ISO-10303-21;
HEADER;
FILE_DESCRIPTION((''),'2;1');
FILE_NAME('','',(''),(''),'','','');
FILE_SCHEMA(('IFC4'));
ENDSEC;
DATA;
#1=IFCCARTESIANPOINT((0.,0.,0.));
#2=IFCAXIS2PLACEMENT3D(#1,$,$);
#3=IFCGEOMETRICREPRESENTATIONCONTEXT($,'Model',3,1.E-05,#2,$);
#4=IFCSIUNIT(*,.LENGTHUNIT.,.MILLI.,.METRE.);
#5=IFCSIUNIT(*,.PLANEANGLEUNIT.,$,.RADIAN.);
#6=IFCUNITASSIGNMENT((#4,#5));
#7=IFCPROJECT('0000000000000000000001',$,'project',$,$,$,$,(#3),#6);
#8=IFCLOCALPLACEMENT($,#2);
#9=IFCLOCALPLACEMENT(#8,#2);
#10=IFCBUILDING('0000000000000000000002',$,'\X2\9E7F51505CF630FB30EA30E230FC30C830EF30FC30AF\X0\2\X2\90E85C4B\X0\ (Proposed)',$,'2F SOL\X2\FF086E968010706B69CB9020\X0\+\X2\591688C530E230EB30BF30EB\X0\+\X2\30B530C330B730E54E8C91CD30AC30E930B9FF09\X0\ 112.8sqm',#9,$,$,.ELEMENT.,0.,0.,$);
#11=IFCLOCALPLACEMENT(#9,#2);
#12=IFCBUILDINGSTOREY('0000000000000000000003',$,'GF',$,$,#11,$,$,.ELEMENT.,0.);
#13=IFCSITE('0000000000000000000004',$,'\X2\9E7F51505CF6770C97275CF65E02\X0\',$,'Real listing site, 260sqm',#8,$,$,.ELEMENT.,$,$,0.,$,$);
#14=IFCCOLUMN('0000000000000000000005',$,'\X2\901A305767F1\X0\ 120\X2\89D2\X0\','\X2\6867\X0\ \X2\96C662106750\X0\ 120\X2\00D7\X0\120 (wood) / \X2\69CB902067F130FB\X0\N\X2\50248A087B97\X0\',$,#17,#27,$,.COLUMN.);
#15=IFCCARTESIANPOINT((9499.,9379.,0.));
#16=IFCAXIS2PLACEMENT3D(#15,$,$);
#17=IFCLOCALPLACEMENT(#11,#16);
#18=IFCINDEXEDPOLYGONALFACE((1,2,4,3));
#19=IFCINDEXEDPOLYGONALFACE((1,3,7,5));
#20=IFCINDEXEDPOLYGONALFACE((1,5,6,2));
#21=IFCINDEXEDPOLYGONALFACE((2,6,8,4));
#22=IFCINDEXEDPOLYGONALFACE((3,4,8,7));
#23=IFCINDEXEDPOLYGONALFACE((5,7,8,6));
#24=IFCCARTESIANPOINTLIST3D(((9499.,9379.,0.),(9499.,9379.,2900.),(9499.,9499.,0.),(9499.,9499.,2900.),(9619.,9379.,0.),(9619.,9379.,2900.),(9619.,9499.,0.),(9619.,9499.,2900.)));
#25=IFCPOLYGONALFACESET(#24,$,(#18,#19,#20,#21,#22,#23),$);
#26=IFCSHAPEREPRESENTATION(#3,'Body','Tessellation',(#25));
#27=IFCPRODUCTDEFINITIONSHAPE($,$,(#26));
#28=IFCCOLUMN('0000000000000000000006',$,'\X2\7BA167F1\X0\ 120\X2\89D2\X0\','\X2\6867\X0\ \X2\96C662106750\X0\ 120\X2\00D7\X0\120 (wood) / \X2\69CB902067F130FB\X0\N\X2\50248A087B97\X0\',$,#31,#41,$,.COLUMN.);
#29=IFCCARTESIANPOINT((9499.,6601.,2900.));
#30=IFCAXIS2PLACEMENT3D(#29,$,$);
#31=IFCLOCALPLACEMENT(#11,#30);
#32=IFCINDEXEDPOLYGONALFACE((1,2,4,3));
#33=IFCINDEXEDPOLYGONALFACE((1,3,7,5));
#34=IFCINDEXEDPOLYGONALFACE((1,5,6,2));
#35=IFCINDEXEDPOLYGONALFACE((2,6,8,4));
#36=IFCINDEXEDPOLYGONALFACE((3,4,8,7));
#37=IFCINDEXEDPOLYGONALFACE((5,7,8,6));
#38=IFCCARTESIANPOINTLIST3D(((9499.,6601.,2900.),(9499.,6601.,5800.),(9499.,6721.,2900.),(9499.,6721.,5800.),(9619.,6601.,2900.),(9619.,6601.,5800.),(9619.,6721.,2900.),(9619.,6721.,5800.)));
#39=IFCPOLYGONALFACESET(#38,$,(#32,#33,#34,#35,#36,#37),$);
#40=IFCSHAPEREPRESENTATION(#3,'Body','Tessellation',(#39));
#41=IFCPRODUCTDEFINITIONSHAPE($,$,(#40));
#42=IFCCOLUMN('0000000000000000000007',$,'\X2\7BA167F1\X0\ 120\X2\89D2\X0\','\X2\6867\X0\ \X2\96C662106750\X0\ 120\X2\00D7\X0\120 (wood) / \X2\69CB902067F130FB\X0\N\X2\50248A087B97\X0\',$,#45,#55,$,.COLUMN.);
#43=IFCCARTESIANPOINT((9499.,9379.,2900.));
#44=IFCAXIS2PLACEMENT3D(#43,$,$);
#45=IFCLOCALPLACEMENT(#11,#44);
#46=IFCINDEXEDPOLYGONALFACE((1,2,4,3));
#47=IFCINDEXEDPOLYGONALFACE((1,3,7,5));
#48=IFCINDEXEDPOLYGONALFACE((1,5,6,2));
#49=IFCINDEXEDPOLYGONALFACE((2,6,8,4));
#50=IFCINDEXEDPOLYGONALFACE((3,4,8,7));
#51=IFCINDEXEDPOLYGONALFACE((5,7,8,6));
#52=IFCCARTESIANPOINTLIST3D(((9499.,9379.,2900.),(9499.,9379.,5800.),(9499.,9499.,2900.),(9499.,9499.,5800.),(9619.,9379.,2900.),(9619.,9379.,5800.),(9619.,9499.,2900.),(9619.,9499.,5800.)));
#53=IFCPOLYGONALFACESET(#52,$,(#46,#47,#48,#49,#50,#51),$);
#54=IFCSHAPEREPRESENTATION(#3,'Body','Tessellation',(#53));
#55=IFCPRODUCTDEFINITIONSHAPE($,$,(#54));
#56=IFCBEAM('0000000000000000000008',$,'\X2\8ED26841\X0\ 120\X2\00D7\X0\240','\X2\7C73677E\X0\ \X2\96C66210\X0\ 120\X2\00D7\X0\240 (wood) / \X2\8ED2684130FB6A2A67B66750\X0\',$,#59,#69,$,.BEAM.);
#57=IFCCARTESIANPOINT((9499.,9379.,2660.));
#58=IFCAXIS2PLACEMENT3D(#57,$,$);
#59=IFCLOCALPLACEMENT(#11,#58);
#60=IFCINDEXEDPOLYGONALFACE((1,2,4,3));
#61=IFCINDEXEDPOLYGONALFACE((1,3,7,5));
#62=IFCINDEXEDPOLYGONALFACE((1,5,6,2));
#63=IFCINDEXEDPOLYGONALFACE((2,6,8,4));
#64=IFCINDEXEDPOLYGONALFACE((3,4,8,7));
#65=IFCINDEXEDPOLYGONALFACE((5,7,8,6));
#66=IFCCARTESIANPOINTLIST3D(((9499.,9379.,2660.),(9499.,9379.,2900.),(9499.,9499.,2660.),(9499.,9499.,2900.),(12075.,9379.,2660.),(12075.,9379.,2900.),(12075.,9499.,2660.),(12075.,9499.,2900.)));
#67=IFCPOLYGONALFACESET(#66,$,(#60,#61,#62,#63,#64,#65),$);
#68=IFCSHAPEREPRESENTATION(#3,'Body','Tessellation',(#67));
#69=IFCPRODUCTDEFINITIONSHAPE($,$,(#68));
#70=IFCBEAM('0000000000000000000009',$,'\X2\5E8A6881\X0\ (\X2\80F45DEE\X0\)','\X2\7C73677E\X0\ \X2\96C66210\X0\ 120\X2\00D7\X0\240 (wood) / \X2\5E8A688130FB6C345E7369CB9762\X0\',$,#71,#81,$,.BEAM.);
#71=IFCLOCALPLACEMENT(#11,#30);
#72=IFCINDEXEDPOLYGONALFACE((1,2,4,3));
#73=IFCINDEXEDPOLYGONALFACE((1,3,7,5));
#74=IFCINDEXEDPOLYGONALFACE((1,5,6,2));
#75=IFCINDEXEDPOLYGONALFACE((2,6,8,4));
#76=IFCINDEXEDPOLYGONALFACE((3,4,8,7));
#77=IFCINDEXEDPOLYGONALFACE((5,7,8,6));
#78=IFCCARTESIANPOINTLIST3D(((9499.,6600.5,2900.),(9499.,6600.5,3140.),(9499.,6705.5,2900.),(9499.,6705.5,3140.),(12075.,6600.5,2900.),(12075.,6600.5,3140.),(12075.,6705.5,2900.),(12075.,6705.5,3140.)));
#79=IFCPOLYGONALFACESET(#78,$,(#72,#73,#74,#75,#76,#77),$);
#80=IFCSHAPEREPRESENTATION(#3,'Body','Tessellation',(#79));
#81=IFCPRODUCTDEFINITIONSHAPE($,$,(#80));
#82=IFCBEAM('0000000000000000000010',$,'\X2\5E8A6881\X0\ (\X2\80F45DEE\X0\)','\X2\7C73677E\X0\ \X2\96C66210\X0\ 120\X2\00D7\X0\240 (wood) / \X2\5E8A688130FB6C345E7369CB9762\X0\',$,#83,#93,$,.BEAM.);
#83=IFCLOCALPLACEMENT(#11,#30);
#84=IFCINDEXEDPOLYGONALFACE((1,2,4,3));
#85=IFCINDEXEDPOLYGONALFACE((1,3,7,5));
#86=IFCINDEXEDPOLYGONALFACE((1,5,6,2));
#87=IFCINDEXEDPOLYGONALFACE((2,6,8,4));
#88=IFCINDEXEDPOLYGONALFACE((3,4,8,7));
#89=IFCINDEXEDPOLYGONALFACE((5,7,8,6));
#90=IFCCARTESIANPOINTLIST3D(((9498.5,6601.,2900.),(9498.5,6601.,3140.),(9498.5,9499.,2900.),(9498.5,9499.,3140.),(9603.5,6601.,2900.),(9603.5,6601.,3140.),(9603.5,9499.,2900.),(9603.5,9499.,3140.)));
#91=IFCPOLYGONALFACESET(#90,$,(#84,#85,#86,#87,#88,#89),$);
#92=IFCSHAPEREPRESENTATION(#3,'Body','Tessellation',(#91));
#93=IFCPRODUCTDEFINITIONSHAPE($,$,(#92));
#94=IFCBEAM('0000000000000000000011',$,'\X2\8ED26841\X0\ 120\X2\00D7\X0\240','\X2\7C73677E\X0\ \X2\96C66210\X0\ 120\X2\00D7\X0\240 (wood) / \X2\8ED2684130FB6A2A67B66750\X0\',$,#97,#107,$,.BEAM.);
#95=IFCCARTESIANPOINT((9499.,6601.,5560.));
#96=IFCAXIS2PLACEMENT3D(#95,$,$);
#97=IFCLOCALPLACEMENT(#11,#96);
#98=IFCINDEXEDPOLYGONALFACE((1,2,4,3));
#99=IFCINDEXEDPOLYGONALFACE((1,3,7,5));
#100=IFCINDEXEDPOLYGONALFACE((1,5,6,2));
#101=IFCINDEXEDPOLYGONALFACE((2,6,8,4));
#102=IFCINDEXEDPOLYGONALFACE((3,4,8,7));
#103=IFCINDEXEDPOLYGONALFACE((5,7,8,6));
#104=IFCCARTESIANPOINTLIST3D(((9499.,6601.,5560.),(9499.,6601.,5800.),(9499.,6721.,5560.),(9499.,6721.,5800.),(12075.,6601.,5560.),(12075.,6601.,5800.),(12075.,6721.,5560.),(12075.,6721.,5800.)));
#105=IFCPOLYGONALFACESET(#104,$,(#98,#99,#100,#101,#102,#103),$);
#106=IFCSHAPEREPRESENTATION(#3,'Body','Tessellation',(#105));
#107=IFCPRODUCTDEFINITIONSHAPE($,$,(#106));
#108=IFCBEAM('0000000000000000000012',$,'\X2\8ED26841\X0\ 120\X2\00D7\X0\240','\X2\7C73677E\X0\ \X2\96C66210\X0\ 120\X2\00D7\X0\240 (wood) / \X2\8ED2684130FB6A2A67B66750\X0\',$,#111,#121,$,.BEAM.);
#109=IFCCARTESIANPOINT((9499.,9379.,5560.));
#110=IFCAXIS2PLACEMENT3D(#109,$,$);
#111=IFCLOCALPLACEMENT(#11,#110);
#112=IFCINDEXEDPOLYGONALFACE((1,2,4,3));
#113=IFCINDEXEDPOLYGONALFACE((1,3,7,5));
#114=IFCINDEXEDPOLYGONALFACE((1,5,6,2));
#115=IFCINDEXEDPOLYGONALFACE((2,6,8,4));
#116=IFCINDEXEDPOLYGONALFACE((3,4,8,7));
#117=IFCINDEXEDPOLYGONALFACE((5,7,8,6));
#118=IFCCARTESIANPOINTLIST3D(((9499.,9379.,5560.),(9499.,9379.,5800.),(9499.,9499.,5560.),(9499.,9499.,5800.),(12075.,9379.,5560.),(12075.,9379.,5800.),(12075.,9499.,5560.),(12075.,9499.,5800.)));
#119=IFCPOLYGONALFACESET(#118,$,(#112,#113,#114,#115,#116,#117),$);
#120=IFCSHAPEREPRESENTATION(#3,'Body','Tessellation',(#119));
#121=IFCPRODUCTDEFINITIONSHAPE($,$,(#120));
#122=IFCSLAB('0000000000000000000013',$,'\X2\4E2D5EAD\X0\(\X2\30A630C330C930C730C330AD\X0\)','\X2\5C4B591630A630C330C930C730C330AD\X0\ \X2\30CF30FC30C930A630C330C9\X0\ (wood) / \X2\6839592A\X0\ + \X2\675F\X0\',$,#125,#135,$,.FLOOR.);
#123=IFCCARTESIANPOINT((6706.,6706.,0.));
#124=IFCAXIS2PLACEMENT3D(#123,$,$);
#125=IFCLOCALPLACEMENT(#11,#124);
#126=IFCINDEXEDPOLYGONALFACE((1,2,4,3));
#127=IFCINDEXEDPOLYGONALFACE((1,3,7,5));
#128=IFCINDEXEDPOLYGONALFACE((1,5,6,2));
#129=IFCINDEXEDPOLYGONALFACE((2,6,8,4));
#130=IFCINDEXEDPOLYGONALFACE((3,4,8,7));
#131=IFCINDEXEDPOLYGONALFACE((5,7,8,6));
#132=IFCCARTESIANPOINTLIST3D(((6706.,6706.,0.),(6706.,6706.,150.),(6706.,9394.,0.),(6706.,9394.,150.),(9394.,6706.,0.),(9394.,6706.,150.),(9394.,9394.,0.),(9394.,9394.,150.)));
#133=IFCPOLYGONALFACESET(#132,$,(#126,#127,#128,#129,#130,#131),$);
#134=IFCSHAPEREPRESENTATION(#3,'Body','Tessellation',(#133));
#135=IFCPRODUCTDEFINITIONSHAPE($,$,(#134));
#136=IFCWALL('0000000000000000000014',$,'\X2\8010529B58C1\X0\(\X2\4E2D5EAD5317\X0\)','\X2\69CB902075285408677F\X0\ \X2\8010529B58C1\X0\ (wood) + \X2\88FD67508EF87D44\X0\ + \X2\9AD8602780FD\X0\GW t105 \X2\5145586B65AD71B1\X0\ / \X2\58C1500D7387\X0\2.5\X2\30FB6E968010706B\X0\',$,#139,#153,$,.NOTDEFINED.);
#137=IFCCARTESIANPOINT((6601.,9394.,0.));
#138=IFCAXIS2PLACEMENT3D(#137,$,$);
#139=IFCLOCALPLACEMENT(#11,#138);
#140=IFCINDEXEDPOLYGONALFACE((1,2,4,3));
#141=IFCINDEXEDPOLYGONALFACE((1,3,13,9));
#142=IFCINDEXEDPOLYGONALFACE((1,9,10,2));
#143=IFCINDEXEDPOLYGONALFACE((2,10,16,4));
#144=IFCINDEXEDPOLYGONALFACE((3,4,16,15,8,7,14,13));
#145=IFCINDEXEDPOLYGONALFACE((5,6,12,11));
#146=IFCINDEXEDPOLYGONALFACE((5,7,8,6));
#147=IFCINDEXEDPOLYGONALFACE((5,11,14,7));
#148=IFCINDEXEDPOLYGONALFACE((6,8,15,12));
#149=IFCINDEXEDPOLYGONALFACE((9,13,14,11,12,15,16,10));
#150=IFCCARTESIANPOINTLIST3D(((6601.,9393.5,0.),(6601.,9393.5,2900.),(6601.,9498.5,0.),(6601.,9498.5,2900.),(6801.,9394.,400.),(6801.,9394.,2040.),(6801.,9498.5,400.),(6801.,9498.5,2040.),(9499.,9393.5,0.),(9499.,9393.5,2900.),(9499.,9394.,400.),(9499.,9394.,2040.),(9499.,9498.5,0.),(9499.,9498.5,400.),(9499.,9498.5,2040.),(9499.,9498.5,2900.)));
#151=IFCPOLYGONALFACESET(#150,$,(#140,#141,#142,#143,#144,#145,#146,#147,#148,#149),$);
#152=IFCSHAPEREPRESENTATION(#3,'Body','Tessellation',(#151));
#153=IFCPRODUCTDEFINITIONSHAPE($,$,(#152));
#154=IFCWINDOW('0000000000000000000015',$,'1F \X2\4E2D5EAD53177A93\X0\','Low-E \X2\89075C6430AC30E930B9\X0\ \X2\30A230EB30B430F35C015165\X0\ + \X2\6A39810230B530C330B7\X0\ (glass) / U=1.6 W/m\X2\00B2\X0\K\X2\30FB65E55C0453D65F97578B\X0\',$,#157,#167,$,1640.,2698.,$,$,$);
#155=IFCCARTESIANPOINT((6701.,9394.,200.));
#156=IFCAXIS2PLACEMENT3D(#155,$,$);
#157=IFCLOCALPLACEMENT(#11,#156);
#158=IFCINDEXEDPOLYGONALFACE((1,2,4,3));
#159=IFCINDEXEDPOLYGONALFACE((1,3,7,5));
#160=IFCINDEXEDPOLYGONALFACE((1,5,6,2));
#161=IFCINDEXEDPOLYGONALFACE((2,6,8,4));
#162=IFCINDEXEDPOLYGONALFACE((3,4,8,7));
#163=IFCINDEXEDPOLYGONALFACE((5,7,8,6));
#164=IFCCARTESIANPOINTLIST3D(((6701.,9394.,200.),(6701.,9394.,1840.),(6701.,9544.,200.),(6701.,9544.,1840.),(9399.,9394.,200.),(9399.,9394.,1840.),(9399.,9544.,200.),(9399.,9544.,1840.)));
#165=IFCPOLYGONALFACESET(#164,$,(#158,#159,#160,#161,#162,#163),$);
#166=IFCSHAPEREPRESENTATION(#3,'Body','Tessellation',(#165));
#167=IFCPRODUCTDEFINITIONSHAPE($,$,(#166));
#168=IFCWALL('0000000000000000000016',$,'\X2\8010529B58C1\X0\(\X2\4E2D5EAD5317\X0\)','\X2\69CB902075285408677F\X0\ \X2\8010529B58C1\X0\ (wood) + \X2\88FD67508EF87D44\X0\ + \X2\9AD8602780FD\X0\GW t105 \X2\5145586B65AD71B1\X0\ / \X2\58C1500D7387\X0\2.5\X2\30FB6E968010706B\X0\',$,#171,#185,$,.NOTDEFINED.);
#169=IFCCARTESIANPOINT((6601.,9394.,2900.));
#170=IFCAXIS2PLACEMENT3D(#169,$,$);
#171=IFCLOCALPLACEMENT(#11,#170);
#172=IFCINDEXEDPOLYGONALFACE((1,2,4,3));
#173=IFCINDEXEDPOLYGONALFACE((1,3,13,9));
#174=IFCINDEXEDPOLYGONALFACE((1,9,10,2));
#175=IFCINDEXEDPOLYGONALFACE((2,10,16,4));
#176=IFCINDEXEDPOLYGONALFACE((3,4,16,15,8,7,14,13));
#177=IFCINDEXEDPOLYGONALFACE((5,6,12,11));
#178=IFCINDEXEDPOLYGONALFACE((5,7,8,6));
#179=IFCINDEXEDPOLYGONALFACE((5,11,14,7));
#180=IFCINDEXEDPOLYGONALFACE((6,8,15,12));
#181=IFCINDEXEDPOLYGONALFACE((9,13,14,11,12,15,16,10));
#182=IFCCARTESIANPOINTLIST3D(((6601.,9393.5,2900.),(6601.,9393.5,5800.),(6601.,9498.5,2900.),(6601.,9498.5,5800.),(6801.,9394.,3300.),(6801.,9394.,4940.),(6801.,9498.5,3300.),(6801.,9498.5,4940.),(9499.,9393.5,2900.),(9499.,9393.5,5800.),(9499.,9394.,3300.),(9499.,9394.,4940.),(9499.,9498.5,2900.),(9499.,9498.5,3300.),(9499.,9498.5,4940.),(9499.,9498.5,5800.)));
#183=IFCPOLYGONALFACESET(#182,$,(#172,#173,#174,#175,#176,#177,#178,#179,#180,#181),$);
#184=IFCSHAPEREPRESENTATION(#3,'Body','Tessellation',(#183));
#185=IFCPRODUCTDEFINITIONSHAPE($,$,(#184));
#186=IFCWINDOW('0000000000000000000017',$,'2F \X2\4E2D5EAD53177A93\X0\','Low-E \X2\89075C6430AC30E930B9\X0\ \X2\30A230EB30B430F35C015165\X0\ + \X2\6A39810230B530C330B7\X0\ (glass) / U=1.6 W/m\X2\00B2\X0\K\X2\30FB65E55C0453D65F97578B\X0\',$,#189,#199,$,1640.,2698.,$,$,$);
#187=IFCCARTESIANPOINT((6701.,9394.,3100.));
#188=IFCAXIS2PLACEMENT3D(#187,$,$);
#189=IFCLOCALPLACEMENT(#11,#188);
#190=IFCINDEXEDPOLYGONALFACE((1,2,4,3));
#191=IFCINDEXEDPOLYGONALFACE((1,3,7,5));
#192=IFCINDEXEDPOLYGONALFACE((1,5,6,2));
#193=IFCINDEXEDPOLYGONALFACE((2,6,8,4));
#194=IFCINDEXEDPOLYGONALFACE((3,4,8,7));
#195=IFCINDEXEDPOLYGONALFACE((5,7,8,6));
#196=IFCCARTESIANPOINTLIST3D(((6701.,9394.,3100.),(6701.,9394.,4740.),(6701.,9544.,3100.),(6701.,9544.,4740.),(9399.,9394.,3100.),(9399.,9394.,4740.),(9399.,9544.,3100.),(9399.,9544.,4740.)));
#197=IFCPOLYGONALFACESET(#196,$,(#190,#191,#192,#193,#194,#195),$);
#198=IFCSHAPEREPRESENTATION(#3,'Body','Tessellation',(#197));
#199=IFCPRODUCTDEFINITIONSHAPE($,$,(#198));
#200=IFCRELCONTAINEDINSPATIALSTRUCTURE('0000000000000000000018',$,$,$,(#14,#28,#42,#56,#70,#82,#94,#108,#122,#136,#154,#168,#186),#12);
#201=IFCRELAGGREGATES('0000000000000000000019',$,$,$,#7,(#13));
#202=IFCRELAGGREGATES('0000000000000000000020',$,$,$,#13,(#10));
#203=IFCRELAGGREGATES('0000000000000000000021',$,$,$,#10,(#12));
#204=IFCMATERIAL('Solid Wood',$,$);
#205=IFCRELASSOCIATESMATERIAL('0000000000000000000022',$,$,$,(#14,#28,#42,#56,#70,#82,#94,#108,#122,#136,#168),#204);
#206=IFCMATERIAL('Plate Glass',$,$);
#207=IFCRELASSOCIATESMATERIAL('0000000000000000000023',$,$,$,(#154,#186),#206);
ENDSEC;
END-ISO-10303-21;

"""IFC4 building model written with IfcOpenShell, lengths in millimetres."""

from ifc_helpers import new_model, si_unit, frame, frame_2d, origin, place, context, project, spatial, rectangle, extrude, material, element, fill, save


model = new_model("IFC4")

# Units and contexts
model_context = context("Model", 3, precision=1e-05, world=origin())
ifc_project = project(units=[si_unit("LENGTHUNIT", "METRE", prefix="MILLI"), si_unit("PLANEANGLEUNIT", "RADIAN")], contexts=[model_context])

# Site, building, storey
site_placement = place(None, origin())
site = spatial("IfcSite", under=ifc_project, at=site_placement, Name="鹿児島県霧島市", ObjectType="Real listing site, 260sqm", CompositionType="ELEMENT", RefElevation=0.0)
building_placement = place(site_placement, origin())
building = spatial("IfcBuilding", under=site, at=building_placement, Name="鹿児島・リモートワーク2部屋 (Proposed)", ObjectType="2F SOL（準耐火構造+外装モルタル+サッシュ二重ガラス） 112.8sqm", CompositionType="ELEMENT", ElevationOfRefHeight=0.0, ElevationOfTerrain=0.0)
storey_placement = place(building_placement, origin())
storey = spatial("IfcBuildingStorey", under=building, at=storey_placement, Name="GF", CompositionType="ELEMENT", Elevation=0.0)

# Columns
ifc_material_1 = material(Name="Solid Wood")
column_1_placement = place(storey_placement, frame((9499.0, 9379.0, 0.0)))
element("IfcColumn", 1, at=column_1_placement, inside=storey, material=ifc_material_1, Name="通し柱 120角", Description="桧 集成材 120×120 (wood) / 構造柱・N値計算", PredefinedType="COLUMN", context=model_context, shape_type="SweptSolid", body=[
    extrude(rectangle(XDim=120.0, YDim=120.0, at=frame_2d((60.0, 60.0))), frame((9499.0, 9379.0, 0.0)), (0.0, 0.0, 1.0), 2900.0),
])
column_2_placement = place(storey_placement, frame((9499.0, 6601.0, 2900.0)))
element("IfcColumn", 2, at=column_2_placement, inside=storey, material=ifc_material_1, Name="管柱 120角", Description="桧 集成材 120×120 (wood) / 構造柱・N値計算", PredefinedType="COLUMN", context=model_context, shape_type="SweptSolid", body=[
    extrude(rectangle(XDim=120.0, YDim=120.0, at=frame_2d((60.0, 60.0))), frame((9499.0, 6601.0, 2900.0)), (0.0, 0.0, 1.0), 2900.0),
])
column_3_placement = place(storey_placement, frame((9499.0, 9379.0, 2900.0)))
element("IfcColumn", 3, at=column_3_placement, inside=storey, material=ifc_material_1, Name="管柱 120角", Description="桧 集成材 120×120 (wood) / 構造柱・N値計算", PredefinedType="COLUMN", context=model_context, shape_type="SweptSolid", body=[
    extrude(rectangle(XDim=120.0, YDim=120.0, at=frame_2d((60.0, 60.0))), frame((9499.0, 9379.0, 2900.0)), (0.0, 0.0, 1.0), 2900.0),
])

# Beams
beam_1_placement = place(storey_placement, frame((9499.0, 9379.0, 2660.0)))
element("IfcBeam", 4, at=beam_1_placement, inside=storey, material=ifc_material_1, Name="軒桁 120×240", Description="米松 集成 120×240 (wood) / 軒桁・横架材", PredefinedType="BEAM", context=model_context, shape_type="SweptSolid", body=[
    extrude(rectangle(XDim=2576.0, YDim=120.0, at=frame_2d((1288.0, 60.0))), frame((9499.0, 9379.0, 2660.0)), (0.0, 0.0, 1.0), 240.0),
])
beam_2_placement = place(storey_placement, frame((9499.0, 6601.0, 2900.0)))
element("IfcBeam", 5, at=beam_2_placement, inside=storey, material=ifc_material_1, Name="床梁 (胴差)", Description="米松 集成 120×240 (wood) / 床梁・水平構面", PredefinedType="BEAM", context=model_context, shape_type="SweptSolid", body=[
    extrude(rectangle(XDim=2576.0, YDim=105.0, at=frame_2d((1288.0, 52.0))), frame((9499.0, 6601.0, 2900.0)), (0.0, 0.0, 1.0), 240.0),
])
beam_3_placement = place(storey_placement, frame((9499.0, 6601.0, 2900.0)))
element("IfcBeam", 6, at=beam_3_placement, inside=storey, material=ifc_material_1, Name="床梁 (胴差)", Description="米松 集成 120×240 (wood) / 床梁・水平構面", PredefinedType="BEAM", context=model_context, shape_type="SweptSolid", body=[
    extrude(rectangle(XDim=105.0, YDim=2898.0, at=frame_2d((52.0, 1449.0))), frame((9499.0, 6601.0, 2900.0)), (0.0, 0.0, 1.0), 240.0),
])
beam_4_placement = place(storey_placement, frame((9499.0, 6601.0, 5560.0)))
element("IfcBeam", 7, at=beam_4_placement, inside=storey, material=ifc_material_1, Name="軒桁 120×240", Description="米松 集成 120×240 (wood) / 軒桁・横架材", PredefinedType="BEAM", context=model_context, shape_type="SweptSolid", body=[
    extrude(rectangle(XDim=2576.0, YDim=120.0, at=frame_2d((1288.0, 60.0))), frame((9499.0, 6601.0, 5560.0)), (0.0, 0.0, 1.0), 240.0),
])
beam_5_placement = place(storey_placement, frame((9499.0, 9379.0, 5560.0)))
element("IfcBeam", 8, at=beam_5_placement, inside=storey, material=ifc_material_1, Name="軒桁 120×240", Description="米松 集成 120×240 (wood) / 軒桁・横架材", PredefinedType="BEAM", context=model_context, shape_type="SweptSolid", body=[
    extrude(rectangle(XDim=2576.0, YDim=120.0, at=frame_2d((1288.0, 60.0))), frame((9499.0, 9379.0, 5560.0)), (0.0, 0.0, 1.0), 240.0),
])

# Slab
slab_placement = place(storey_placement, frame((6706.0, 6706.0, 0.0)))
element("IfcSlab", 9, at=slab_placement, inside=storey, material=ifc_material_1, Name="中庭(ウッドデッキ)", Description="屋外ウッドデッキ ハードウッド (wood) / 根太 + 束", PredefinedType="FLOOR", context=model_context, shape_type="SweptSolid", body=[
    extrude(rectangle(XDim=2688.0, YDim=2688.0, at=frame_2d((1344.0, 1344.0))), frame((6706.0, 6706.0, 0.0)), (0.0, 0.0, 1.0), 150.0),
])

# Wall, opening, window
wall_1_placement = place(storey_placement, frame((6601.0, 9394.0, 0.0)))
wall_1 = element("IfcWall", 10, at=wall_1_placement, inside=storey, material=ifc_material_1, Name="耐力壁(中庭北)", Description="構造用合板 耐力壁 (wood) + 製材軸組 + 高性能GW t105 充填断熱 / 壁倍率2.5・準耐火", PredefinedType="NOTDEFINED", context=model_context, shape_type="SweptSolid", body=[
    extrude(rectangle(XDim=2898.0, YDim=105.0, at=frame_2d((1449.0, 52.0))), frame((6601.0, 9394.0, 0.0)), (0.0, 0.0, 1.0), 2900.0),
])
opening_1_placement = place(storey_placement, frame((6701.0, 9394.0, 200.0)))
opening_1 = element("IfcOpeningElement", 11, at=opening_1_placement, cuts=wall_1, PredefinedType="NOTDEFINED", context=model_context, shape_type="SweptSolid", body=[
    extrude(rectangle(XDim=2698.0, YDim=150.0, at=frame_2d((1349.0, 75.0))), frame((6701.0, 9394.0, 200.0)), (0.0, 0.0, 1.0), 1640.0),
])
ifc_material_2 = material(Name="Plate Glass")
window_1_placement = place(storey_placement, frame((6701.0, 9394.0, 200.0)))
window_1 = element("IfcWindow", 12, at=window_1_placement, inside=storey, material=ifc_material_2, Name="1F 中庭北窓", Description="Low-E 複層ガラス アルゴン封入 + 樹脂サッシ (glass) / U=1.6 W/m²K・日射取得型", OverallHeight=1640.0, OverallWidth=2698.0, context=model_context, shape_type="SweptSolid", body=[
    extrude(rectangle(XDim=2698.0, YDim=150.0, at=frame_2d((1349.0, 75.0))), frame((6701.0, 9394.0, 200.0)), (0.0, 0.0, 1.0), 1640.0),
])
fill(opening_1, window_1)

# Wall, opening, window
wall_2_placement = place(storey_placement, frame((6601.0, 9394.0, 2900.0)))
wall_2 = element("IfcWall", 13, at=wall_2_placement, inside=storey, material=ifc_material_1, Name="耐力壁(中庭北)", Description="構造用合板 耐力壁 (wood) + 製材軸組 + 高性能GW t105 充填断熱 / 壁倍率2.5・準耐火", PredefinedType="NOTDEFINED", context=model_context, shape_type="SweptSolid", body=[
    extrude(rectangle(XDim=2898.0, YDim=105.0, at=frame_2d((1449.0, 52.0))), frame((6601.0, 9394.0, 2900.0)), (0.0, 0.0, 1.0), 2900.0),
])
opening_2_placement = place(storey_placement, frame((6701.0, 9394.0, 3100.0)))
opening_2 = element("IfcOpeningElement", 14, at=opening_2_placement, cuts=wall_2, PredefinedType="NOTDEFINED", context=model_context, shape_type="SweptSolid", body=[
    extrude(rectangle(XDim=2698.0, YDim=150.0, at=frame_2d((1349.0, 75.0))), frame((6701.0, 9394.0, 3100.0)), (0.0, 0.0, 1.0), 1640.0),
])
window_2_placement = place(storey_placement, frame((6701.0, 9394.0, 3100.0)))
window_2 = element("IfcWindow", 15, at=window_2_placement, inside=storey, material=ifc_material_2, Name="2F 中庭北窓", Description="Low-E 複層ガラス アルゴン封入 + 樹脂サッシ (glass) / U=1.6 W/m²K・日射取得型", OverallHeight=1640.0, OverallWidth=2698.0, context=model_context, shape_type="SweptSolid", body=[
    extrude(rectangle(XDim=2698.0, YDim=150.0, at=frame_2d((1349.0, 75.0))), frame((6701.0, 9394.0, 3100.0)), (0.0, 0.0, 1.0), 1640.0),
])
fill(opening_2, window_2)

save(model, "model.ifc")
